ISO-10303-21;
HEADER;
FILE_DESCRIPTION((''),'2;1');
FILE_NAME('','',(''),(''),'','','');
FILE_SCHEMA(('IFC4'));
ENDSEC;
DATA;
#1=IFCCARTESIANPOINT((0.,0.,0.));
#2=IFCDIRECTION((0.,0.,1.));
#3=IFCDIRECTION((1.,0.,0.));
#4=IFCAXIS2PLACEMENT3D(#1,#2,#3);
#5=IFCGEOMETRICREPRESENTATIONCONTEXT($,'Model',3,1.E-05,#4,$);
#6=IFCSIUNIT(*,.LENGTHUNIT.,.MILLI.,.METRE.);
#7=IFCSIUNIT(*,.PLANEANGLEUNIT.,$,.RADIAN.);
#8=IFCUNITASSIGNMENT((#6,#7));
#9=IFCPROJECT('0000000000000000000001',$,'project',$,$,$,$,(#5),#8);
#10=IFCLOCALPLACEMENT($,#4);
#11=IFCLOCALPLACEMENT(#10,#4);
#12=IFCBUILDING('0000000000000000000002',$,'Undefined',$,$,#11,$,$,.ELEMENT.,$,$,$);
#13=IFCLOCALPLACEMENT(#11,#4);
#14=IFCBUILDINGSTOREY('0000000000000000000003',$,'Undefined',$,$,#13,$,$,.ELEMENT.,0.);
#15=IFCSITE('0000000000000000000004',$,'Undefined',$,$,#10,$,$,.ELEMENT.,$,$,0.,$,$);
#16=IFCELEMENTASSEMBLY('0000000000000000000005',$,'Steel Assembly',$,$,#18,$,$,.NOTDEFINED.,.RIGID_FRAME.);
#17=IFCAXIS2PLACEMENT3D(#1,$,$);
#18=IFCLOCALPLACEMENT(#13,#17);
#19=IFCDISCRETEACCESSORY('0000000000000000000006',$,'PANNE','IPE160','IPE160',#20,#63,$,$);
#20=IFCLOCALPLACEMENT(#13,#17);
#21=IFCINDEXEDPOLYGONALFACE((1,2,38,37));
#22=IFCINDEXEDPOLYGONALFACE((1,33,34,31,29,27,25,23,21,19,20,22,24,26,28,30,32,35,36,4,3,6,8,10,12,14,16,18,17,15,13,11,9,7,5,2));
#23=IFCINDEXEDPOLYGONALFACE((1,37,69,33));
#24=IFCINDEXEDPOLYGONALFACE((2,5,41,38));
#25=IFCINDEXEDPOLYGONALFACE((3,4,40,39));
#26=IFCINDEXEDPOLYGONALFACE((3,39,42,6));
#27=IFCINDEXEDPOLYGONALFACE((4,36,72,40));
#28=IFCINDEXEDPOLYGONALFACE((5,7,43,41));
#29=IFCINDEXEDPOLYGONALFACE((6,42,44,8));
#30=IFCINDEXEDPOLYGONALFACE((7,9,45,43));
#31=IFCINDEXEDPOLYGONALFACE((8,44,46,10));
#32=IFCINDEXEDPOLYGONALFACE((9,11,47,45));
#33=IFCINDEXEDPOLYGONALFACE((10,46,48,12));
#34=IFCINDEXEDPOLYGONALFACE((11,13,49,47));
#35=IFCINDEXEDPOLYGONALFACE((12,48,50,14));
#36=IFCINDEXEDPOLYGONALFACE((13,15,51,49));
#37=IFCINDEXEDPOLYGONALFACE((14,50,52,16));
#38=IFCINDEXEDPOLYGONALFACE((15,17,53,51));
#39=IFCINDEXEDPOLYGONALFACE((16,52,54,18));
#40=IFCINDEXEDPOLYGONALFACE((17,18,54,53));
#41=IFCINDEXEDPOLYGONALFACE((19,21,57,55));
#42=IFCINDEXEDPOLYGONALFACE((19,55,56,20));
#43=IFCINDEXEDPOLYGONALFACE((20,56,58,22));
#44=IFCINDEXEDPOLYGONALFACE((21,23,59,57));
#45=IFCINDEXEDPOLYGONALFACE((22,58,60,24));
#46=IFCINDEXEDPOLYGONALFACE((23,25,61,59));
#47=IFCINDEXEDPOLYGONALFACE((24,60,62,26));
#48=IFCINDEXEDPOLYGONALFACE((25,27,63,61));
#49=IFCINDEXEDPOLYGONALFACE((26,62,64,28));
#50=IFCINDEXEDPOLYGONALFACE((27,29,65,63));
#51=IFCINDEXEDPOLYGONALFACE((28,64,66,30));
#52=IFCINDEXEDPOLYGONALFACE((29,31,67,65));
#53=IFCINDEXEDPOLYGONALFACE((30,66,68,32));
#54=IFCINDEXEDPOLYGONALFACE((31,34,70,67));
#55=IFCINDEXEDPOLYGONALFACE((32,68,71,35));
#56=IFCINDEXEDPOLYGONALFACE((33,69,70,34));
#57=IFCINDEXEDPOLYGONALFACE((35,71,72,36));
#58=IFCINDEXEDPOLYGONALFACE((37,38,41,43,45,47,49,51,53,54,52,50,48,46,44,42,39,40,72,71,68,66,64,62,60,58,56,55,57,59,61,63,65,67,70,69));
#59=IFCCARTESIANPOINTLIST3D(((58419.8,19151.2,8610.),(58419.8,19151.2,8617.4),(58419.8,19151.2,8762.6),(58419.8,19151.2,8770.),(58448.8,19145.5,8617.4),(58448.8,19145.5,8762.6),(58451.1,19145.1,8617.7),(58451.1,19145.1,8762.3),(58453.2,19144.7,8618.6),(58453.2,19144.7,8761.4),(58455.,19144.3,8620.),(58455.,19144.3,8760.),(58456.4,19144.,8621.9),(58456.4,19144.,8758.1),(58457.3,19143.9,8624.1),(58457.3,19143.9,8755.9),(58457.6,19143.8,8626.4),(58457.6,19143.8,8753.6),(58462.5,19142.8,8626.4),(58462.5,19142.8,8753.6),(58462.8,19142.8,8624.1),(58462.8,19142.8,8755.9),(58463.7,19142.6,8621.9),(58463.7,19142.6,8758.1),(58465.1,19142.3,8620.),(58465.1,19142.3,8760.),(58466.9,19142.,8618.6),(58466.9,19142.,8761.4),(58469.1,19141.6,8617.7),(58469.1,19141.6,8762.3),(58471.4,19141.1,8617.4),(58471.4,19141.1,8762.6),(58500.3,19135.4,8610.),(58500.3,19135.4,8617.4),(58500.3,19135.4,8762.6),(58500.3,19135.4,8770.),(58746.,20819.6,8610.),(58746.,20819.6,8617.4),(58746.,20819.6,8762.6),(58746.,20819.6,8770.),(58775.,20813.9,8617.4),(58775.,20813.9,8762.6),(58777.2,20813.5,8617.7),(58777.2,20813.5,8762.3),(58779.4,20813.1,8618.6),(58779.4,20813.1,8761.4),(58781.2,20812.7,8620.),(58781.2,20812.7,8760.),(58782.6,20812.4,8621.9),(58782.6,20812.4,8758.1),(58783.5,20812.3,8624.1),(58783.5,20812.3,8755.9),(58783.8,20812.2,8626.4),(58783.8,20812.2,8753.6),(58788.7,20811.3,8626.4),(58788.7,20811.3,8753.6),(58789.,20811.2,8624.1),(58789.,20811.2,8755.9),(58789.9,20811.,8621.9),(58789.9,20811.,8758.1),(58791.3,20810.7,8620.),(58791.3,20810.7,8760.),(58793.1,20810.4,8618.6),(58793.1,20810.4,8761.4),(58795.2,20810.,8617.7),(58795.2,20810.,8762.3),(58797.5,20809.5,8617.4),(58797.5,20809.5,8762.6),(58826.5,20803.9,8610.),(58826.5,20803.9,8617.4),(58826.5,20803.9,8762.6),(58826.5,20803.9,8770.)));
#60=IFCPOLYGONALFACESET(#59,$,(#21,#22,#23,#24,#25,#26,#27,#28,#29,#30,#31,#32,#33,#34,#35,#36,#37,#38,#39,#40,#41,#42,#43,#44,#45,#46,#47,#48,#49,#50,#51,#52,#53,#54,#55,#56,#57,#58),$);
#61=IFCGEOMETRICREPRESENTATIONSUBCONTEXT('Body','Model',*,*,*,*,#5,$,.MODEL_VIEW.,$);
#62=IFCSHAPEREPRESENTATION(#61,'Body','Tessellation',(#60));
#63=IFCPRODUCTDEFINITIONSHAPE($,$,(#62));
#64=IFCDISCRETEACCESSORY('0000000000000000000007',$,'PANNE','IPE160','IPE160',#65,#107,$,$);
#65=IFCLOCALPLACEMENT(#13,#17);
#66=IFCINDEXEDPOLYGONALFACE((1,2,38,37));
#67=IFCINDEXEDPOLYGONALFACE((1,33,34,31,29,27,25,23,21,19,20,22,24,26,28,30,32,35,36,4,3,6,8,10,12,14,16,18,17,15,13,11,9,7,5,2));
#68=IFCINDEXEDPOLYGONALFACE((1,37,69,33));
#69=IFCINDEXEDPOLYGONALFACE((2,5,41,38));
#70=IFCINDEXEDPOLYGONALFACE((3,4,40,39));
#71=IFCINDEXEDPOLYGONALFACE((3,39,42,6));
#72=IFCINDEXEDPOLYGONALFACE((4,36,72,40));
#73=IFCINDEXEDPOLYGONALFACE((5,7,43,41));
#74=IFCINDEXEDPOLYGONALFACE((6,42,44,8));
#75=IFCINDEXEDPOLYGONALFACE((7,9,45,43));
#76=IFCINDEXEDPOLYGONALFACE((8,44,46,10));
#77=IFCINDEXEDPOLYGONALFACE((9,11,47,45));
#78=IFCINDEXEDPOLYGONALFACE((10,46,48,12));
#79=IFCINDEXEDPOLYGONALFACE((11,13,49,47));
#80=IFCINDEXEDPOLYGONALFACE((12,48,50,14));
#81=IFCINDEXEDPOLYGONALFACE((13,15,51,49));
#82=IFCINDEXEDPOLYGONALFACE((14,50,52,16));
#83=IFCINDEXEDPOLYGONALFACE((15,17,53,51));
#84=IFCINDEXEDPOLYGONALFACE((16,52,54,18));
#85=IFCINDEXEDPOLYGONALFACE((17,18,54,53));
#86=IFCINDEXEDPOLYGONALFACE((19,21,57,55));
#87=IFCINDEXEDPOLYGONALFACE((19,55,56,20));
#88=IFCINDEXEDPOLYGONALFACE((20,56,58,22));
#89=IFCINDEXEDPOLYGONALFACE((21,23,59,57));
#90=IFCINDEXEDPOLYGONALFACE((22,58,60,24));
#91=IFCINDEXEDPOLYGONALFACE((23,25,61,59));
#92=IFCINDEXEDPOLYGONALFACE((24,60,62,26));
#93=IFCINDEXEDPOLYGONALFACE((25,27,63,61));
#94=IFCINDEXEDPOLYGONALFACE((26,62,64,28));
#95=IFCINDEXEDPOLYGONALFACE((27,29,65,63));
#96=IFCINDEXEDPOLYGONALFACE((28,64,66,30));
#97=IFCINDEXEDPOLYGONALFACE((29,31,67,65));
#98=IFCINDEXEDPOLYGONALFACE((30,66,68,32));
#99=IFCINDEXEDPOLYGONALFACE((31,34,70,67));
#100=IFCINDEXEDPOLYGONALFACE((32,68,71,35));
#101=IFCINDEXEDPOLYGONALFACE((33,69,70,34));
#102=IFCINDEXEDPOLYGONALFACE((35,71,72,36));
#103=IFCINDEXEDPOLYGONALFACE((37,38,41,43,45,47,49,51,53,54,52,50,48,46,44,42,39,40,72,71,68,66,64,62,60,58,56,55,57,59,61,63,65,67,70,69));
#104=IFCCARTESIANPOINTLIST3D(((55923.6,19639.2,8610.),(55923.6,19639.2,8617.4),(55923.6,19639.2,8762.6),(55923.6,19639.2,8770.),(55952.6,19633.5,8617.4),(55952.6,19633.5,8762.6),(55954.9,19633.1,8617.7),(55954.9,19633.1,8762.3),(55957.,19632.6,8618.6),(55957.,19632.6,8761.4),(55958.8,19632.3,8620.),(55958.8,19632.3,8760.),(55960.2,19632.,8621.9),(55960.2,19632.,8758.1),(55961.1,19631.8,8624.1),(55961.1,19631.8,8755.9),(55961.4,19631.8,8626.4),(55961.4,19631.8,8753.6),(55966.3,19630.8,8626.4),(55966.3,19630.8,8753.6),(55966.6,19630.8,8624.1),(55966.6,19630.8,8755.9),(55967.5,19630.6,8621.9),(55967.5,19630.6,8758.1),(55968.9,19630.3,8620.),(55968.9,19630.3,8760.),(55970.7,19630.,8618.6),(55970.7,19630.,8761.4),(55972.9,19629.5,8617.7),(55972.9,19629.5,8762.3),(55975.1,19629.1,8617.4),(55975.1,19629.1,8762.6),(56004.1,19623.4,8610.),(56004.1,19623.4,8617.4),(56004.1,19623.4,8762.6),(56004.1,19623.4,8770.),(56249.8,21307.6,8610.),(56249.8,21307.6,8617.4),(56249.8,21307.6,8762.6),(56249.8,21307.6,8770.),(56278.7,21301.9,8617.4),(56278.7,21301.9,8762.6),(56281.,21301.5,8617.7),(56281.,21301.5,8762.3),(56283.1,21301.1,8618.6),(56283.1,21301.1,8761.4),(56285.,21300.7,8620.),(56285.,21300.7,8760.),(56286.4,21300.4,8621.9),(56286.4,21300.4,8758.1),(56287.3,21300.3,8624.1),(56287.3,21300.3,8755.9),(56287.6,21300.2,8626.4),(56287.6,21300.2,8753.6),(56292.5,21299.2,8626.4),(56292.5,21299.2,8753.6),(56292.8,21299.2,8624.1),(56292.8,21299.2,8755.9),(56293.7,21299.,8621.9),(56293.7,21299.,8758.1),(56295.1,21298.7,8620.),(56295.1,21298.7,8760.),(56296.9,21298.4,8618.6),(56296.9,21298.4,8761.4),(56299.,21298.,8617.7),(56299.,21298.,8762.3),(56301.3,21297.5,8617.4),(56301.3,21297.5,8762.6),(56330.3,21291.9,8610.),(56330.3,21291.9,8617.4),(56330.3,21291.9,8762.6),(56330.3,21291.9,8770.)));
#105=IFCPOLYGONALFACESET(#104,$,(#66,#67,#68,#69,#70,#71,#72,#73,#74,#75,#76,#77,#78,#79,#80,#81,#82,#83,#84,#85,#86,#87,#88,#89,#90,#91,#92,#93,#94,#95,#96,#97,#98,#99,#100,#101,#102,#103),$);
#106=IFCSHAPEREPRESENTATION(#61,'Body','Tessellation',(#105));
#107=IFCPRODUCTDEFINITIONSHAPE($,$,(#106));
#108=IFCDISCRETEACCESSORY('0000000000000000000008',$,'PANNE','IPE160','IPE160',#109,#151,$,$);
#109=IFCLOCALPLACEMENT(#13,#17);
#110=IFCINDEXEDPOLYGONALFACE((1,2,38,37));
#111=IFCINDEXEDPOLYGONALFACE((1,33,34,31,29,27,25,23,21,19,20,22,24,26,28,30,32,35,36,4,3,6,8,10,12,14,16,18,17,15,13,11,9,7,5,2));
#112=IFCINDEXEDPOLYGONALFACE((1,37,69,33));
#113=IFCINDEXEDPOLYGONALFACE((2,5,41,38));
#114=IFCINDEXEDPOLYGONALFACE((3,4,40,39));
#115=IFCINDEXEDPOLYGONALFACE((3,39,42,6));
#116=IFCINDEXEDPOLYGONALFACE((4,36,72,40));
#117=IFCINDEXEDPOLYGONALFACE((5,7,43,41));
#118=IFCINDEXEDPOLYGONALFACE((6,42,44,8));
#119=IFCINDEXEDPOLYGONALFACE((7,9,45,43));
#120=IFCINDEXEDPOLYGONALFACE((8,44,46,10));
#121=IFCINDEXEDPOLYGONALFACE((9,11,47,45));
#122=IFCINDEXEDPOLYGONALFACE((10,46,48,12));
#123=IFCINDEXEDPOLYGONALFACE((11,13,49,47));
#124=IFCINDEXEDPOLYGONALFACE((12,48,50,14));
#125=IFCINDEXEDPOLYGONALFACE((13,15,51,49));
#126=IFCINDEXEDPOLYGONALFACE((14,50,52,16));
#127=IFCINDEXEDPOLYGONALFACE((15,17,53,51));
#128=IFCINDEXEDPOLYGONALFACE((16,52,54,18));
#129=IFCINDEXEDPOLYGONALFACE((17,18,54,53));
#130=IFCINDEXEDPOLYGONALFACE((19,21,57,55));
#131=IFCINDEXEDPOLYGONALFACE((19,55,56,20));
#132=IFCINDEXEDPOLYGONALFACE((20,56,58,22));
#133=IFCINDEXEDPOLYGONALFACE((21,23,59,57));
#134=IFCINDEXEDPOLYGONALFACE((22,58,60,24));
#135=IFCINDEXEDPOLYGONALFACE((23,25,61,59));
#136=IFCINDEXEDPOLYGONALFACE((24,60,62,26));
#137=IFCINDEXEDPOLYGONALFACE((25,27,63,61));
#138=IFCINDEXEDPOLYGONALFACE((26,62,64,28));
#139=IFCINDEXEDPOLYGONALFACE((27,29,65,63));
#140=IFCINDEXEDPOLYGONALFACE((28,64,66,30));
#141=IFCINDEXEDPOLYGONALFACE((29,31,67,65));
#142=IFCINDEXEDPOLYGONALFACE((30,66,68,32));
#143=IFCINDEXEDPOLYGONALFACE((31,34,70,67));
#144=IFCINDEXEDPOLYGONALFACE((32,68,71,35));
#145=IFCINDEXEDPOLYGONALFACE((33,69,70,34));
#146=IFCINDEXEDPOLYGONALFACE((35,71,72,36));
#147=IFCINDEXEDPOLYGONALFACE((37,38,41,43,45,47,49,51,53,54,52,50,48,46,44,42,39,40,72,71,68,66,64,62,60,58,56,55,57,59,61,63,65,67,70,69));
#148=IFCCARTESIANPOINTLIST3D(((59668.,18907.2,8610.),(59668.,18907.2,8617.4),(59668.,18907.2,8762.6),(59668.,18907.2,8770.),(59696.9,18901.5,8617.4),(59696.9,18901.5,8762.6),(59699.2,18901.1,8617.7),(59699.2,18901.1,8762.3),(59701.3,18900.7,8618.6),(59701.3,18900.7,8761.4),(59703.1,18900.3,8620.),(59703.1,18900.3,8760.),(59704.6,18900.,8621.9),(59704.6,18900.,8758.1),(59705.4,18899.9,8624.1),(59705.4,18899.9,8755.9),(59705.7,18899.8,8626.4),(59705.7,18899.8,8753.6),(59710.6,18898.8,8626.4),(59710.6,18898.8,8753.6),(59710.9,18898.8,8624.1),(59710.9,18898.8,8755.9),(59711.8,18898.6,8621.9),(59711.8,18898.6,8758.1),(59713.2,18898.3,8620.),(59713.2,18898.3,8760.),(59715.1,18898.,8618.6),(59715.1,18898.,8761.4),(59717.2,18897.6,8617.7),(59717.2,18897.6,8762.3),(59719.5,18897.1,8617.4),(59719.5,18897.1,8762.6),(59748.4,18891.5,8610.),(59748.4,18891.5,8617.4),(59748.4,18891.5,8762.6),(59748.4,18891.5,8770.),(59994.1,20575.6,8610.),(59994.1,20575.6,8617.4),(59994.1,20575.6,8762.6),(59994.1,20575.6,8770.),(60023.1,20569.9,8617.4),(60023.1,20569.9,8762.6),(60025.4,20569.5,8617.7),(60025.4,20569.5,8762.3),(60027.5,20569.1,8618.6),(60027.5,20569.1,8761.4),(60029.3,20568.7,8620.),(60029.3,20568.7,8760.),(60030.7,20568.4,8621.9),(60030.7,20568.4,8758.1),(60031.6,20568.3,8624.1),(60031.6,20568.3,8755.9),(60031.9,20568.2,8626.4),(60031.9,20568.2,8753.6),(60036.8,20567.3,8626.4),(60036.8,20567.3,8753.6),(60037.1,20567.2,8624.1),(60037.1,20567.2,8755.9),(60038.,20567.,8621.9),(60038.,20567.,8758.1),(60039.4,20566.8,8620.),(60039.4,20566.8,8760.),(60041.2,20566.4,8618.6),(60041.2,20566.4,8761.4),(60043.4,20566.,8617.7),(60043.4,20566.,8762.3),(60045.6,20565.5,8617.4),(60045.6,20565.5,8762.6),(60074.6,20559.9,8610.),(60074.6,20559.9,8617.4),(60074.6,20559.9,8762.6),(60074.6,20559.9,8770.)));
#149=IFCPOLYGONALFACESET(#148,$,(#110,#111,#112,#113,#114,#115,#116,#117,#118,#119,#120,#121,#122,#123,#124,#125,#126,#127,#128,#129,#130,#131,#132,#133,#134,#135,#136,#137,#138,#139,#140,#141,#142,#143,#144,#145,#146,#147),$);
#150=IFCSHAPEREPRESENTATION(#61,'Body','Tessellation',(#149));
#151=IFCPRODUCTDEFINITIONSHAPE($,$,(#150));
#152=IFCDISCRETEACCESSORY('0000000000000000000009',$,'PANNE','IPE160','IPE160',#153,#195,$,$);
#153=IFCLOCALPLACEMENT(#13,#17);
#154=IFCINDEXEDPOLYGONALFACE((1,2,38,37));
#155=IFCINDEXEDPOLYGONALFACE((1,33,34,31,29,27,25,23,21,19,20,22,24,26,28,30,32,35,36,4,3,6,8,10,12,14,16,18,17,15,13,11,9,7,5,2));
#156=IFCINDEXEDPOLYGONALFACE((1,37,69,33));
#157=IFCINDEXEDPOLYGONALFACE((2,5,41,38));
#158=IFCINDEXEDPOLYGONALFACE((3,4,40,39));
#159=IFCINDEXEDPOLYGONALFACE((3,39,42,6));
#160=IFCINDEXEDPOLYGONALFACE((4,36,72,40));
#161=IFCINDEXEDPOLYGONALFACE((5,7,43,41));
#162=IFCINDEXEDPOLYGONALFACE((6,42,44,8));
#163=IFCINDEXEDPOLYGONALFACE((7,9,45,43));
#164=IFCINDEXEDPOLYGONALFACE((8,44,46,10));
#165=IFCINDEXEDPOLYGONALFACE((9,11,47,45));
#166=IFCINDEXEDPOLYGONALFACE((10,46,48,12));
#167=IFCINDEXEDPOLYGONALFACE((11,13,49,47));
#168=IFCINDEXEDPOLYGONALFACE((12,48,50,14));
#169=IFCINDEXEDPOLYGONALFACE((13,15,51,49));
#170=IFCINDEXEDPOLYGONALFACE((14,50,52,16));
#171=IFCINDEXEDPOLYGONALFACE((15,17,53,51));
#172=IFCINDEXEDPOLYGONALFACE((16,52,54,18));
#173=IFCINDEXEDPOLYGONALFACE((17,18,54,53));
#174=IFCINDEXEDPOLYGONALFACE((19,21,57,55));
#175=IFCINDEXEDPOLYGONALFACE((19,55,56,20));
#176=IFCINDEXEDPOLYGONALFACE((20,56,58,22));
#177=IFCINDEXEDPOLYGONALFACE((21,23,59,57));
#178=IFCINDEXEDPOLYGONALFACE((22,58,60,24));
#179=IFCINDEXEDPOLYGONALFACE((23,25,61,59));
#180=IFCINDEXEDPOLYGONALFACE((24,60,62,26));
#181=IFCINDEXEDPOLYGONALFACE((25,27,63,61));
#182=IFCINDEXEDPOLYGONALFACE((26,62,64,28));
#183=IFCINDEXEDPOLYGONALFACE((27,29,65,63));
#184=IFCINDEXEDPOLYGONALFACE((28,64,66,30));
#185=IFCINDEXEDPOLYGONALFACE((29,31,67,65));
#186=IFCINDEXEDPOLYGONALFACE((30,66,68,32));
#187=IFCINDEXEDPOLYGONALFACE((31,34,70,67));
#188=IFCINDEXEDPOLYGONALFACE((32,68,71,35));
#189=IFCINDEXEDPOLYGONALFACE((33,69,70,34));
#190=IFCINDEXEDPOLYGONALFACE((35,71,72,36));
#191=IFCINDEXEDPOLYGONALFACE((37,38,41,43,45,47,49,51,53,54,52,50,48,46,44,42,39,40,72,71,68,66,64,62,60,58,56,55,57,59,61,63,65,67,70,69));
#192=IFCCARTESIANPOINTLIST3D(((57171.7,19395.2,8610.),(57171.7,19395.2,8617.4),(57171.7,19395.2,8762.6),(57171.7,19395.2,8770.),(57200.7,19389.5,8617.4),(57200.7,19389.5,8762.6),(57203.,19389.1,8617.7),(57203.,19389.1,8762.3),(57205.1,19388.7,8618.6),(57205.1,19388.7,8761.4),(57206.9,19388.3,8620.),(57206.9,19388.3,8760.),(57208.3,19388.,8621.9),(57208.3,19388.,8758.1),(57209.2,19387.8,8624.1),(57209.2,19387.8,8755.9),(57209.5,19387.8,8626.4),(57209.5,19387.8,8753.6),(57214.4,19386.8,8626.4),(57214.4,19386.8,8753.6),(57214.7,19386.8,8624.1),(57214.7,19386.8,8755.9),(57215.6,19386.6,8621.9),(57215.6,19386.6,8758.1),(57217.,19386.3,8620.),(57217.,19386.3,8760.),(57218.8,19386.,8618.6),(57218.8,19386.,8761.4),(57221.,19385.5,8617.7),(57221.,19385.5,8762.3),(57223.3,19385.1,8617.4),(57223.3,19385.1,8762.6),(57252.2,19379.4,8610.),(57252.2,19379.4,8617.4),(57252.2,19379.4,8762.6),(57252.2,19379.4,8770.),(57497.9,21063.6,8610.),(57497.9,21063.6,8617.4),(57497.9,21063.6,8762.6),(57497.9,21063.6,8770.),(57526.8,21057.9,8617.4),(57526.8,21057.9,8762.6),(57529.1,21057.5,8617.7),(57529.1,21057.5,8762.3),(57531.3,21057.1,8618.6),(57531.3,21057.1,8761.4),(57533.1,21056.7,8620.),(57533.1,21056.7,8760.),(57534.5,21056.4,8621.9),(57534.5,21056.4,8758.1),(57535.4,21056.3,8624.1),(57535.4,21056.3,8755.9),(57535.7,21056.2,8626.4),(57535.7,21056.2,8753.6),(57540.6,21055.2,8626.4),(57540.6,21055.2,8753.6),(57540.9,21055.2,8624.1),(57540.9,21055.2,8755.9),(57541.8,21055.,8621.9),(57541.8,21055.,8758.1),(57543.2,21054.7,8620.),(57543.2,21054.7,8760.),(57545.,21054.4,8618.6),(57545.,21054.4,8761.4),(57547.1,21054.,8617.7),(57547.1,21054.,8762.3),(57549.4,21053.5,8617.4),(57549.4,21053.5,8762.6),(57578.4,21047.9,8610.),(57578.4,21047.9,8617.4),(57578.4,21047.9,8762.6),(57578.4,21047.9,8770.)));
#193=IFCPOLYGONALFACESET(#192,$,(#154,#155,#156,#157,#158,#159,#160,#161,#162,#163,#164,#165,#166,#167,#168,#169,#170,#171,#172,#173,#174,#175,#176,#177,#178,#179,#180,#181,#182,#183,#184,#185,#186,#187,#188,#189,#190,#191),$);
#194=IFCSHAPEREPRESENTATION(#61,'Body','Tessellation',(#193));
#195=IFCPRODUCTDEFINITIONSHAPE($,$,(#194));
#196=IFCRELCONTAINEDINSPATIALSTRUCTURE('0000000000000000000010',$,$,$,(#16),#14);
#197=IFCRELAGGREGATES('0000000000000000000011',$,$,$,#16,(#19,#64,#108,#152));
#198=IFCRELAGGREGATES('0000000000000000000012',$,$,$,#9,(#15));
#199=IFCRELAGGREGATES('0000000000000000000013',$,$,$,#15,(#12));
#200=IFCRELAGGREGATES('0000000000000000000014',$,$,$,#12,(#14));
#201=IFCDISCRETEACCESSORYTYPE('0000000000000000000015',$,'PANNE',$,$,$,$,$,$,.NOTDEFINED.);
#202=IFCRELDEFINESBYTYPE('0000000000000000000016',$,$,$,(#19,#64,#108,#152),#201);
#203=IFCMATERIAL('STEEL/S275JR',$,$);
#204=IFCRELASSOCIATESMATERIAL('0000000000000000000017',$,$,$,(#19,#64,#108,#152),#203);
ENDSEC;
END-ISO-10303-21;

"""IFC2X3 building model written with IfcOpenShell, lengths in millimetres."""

from ifc_helpers import new_model, si_unit, frame, origin_with_axes, origin_2d_with_axis, place, context, subcontext, project, spatial, i_section, extrude, material, type_object, element, aggregate, save


model = new_model("IFC2X3")

# Units and contexts
model_context = context("Model", 3, precision=1e-05, world=origin_with_axes())
body_context = subcontext(model_context, "Body", "Model", "MODEL_VIEW")
ifc_project = project(units=[si_unit("LENGTHUNIT", "METRE", prefix="MILLI"), si_unit("PLANEANGLEUNIT", "RADIAN")], contexts=[model_context])

# Site, building, storey
site_placement = place(None, origin_with_axes())
site = spatial("IfcSite", under=ifc_project, at=site_placement, Name="Undefined", CompositionType="ELEMENT", RefElevation=0.0)
building_placement = place(site_placement, origin_with_axes())
building = spatial("IfcBuilding", under=site, at=building_placement, Name="Undefined", CompositionType="ELEMENT")
storey_placement = place(building_placement, origin_with_axes())
storey = spatial("IfcBuildingStorey", under=building, at=storey_placement, Name="Undefined", CompositionType="ELEMENT", Elevation=0.0)

# Shared definitions
ifc_material_1 = material(Name="STEEL/S275JR")

# Element assembly, discrete accessories
assembly_1_placement = place(storey_placement, origin_with_axes())
assembly_1 = element("IfcElementAssembly", 1, at=assembly_1_placement, inside=storey, Name="Steel Assembly", AssemblyPlace="NOTDEFINED", PredefinedType="RIGID_FRAME")
discrete_accessory_type_1 = type_object("IfcDiscreteAccessoryType", Name="PANNE")
discrete_accessory_1_placement = place(assembly_1_placement, frame((58460.1, 19143.3, 8690.0), z_axis=(0.0, 0.0, 1.0), x_axis=(0.191859, 0.981422, 0.0)))
discrete_accessory_1 = element("IfcDiscreteAccessory", 2, at=discrete_accessory_1_placement, type_object=discrete_accessory_type_1, material=ifc_material_1, Name="PANNE", Description="IPE160", ObjectType="IPE160", context=body_context, shape_type="SweptSolid", body=[
    extrude(i_section(OverallWidth=82.0, OverallDepth=160.0, WebThickness=5.0, FlangeThickness=7.4, FilletRadius=9.0, at=origin_2d_with_axis()), frame((1700.0, 0.0, 0.0), z_axis=(-1.0, 0.0, 0.0), x_axis=(0.0, -1.0, 0.0)), (0.0, 0.0, 1.0), 1700.0),
])
discrete_accessory_2_placement = place(assembly_1_placement, frame((55963.9, 19631.3, 8690.0), z_axis=(0.0, 0.0, 1.0), x_axis=(0.191859, 0.981422, 0.0)))
discrete_accessory_2 = element("IfcDiscreteAccessory", 3, at=discrete_accessory_2_placement, type_object=discrete_accessory_type_1, material=ifc_material_1, Name="PANNE", Description="IPE160", ObjectType="IPE160", context=body_context, shape_type="SweptSolid", body=[
    extrude(i_section(OverallWidth=82.0, OverallDepth=160.0, WebThickness=5.0, FlangeThickness=7.4, FilletRadius=9.0, at=origin_2d_with_axis()), frame((1700.0, 0.0, 0.0), z_axis=(-1.0, 0.0, 0.0), x_axis=(0.0, -1.0, 0.0)), (0.0, 0.0, 1.0), 1700.0),
])
discrete_accessory_3_placement = place(assembly_1_placement, frame((59708.2, 18899.3, 8690.0), z_axis=(0.0, 0.0, 1.0), x_axis=(0.191859, 0.981422, 0.0)))
discrete_accessory_3 = element("IfcDiscreteAccessory", 4, at=discrete_accessory_3_placement, type_object=discrete_accessory_type_1, material=ifc_material_1, Name="PANNE", Description="IPE160", ObjectType="IPE160", context=body_context, shape_type="SweptSolid", body=[
    extrude(i_section(OverallWidth=82.0, OverallDepth=160.0, WebThickness=5.0, FlangeThickness=7.4, FilletRadius=9.0, at=origin_2d_with_axis()), frame((1700.0, 0.0, 0.0), z_axis=(-1.0, 0.0, 0.0), x_axis=(0.0, -1.0, 0.0)), (0.0, 0.0, 1.0), 1700.0),
])
discrete_accessory_4_placement = place(assembly_1_placement, frame((57212.0, 19387.3, 8690.0), z_axis=(0.0, 0.0, 1.0), x_axis=(0.191859, 0.981422, 0.0)))
discrete_accessory_4 = element("IfcDiscreteAccessory", 5, at=discrete_accessory_4_placement, type_object=discrete_accessory_type_1, material=ifc_material_1, Name="PANNE", Description="IPE160", ObjectType="IPE160", context=body_context, shape_type="SweptSolid", body=[
    extrude(i_section(OverallWidth=82.0, OverallDepth=160.0, WebThickness=5.0, FlangeThickness=7.4, FilletRadius=9.0, at=origin_2d_with_axis()), frame((1700.0, 0.0, 0.0), z_axis=(-1.0, 0.0, 0.0), x_axis=(0.0, -1.0, 0.0)), (0.0, 0.0, 1.0), 1700.0),
])
aggregate(assembly_1, [discrete_accessory_1, discrete_accessory_2, discrete_accessory_3, discrete_accessory_4])

save(model, "model.ifc")
